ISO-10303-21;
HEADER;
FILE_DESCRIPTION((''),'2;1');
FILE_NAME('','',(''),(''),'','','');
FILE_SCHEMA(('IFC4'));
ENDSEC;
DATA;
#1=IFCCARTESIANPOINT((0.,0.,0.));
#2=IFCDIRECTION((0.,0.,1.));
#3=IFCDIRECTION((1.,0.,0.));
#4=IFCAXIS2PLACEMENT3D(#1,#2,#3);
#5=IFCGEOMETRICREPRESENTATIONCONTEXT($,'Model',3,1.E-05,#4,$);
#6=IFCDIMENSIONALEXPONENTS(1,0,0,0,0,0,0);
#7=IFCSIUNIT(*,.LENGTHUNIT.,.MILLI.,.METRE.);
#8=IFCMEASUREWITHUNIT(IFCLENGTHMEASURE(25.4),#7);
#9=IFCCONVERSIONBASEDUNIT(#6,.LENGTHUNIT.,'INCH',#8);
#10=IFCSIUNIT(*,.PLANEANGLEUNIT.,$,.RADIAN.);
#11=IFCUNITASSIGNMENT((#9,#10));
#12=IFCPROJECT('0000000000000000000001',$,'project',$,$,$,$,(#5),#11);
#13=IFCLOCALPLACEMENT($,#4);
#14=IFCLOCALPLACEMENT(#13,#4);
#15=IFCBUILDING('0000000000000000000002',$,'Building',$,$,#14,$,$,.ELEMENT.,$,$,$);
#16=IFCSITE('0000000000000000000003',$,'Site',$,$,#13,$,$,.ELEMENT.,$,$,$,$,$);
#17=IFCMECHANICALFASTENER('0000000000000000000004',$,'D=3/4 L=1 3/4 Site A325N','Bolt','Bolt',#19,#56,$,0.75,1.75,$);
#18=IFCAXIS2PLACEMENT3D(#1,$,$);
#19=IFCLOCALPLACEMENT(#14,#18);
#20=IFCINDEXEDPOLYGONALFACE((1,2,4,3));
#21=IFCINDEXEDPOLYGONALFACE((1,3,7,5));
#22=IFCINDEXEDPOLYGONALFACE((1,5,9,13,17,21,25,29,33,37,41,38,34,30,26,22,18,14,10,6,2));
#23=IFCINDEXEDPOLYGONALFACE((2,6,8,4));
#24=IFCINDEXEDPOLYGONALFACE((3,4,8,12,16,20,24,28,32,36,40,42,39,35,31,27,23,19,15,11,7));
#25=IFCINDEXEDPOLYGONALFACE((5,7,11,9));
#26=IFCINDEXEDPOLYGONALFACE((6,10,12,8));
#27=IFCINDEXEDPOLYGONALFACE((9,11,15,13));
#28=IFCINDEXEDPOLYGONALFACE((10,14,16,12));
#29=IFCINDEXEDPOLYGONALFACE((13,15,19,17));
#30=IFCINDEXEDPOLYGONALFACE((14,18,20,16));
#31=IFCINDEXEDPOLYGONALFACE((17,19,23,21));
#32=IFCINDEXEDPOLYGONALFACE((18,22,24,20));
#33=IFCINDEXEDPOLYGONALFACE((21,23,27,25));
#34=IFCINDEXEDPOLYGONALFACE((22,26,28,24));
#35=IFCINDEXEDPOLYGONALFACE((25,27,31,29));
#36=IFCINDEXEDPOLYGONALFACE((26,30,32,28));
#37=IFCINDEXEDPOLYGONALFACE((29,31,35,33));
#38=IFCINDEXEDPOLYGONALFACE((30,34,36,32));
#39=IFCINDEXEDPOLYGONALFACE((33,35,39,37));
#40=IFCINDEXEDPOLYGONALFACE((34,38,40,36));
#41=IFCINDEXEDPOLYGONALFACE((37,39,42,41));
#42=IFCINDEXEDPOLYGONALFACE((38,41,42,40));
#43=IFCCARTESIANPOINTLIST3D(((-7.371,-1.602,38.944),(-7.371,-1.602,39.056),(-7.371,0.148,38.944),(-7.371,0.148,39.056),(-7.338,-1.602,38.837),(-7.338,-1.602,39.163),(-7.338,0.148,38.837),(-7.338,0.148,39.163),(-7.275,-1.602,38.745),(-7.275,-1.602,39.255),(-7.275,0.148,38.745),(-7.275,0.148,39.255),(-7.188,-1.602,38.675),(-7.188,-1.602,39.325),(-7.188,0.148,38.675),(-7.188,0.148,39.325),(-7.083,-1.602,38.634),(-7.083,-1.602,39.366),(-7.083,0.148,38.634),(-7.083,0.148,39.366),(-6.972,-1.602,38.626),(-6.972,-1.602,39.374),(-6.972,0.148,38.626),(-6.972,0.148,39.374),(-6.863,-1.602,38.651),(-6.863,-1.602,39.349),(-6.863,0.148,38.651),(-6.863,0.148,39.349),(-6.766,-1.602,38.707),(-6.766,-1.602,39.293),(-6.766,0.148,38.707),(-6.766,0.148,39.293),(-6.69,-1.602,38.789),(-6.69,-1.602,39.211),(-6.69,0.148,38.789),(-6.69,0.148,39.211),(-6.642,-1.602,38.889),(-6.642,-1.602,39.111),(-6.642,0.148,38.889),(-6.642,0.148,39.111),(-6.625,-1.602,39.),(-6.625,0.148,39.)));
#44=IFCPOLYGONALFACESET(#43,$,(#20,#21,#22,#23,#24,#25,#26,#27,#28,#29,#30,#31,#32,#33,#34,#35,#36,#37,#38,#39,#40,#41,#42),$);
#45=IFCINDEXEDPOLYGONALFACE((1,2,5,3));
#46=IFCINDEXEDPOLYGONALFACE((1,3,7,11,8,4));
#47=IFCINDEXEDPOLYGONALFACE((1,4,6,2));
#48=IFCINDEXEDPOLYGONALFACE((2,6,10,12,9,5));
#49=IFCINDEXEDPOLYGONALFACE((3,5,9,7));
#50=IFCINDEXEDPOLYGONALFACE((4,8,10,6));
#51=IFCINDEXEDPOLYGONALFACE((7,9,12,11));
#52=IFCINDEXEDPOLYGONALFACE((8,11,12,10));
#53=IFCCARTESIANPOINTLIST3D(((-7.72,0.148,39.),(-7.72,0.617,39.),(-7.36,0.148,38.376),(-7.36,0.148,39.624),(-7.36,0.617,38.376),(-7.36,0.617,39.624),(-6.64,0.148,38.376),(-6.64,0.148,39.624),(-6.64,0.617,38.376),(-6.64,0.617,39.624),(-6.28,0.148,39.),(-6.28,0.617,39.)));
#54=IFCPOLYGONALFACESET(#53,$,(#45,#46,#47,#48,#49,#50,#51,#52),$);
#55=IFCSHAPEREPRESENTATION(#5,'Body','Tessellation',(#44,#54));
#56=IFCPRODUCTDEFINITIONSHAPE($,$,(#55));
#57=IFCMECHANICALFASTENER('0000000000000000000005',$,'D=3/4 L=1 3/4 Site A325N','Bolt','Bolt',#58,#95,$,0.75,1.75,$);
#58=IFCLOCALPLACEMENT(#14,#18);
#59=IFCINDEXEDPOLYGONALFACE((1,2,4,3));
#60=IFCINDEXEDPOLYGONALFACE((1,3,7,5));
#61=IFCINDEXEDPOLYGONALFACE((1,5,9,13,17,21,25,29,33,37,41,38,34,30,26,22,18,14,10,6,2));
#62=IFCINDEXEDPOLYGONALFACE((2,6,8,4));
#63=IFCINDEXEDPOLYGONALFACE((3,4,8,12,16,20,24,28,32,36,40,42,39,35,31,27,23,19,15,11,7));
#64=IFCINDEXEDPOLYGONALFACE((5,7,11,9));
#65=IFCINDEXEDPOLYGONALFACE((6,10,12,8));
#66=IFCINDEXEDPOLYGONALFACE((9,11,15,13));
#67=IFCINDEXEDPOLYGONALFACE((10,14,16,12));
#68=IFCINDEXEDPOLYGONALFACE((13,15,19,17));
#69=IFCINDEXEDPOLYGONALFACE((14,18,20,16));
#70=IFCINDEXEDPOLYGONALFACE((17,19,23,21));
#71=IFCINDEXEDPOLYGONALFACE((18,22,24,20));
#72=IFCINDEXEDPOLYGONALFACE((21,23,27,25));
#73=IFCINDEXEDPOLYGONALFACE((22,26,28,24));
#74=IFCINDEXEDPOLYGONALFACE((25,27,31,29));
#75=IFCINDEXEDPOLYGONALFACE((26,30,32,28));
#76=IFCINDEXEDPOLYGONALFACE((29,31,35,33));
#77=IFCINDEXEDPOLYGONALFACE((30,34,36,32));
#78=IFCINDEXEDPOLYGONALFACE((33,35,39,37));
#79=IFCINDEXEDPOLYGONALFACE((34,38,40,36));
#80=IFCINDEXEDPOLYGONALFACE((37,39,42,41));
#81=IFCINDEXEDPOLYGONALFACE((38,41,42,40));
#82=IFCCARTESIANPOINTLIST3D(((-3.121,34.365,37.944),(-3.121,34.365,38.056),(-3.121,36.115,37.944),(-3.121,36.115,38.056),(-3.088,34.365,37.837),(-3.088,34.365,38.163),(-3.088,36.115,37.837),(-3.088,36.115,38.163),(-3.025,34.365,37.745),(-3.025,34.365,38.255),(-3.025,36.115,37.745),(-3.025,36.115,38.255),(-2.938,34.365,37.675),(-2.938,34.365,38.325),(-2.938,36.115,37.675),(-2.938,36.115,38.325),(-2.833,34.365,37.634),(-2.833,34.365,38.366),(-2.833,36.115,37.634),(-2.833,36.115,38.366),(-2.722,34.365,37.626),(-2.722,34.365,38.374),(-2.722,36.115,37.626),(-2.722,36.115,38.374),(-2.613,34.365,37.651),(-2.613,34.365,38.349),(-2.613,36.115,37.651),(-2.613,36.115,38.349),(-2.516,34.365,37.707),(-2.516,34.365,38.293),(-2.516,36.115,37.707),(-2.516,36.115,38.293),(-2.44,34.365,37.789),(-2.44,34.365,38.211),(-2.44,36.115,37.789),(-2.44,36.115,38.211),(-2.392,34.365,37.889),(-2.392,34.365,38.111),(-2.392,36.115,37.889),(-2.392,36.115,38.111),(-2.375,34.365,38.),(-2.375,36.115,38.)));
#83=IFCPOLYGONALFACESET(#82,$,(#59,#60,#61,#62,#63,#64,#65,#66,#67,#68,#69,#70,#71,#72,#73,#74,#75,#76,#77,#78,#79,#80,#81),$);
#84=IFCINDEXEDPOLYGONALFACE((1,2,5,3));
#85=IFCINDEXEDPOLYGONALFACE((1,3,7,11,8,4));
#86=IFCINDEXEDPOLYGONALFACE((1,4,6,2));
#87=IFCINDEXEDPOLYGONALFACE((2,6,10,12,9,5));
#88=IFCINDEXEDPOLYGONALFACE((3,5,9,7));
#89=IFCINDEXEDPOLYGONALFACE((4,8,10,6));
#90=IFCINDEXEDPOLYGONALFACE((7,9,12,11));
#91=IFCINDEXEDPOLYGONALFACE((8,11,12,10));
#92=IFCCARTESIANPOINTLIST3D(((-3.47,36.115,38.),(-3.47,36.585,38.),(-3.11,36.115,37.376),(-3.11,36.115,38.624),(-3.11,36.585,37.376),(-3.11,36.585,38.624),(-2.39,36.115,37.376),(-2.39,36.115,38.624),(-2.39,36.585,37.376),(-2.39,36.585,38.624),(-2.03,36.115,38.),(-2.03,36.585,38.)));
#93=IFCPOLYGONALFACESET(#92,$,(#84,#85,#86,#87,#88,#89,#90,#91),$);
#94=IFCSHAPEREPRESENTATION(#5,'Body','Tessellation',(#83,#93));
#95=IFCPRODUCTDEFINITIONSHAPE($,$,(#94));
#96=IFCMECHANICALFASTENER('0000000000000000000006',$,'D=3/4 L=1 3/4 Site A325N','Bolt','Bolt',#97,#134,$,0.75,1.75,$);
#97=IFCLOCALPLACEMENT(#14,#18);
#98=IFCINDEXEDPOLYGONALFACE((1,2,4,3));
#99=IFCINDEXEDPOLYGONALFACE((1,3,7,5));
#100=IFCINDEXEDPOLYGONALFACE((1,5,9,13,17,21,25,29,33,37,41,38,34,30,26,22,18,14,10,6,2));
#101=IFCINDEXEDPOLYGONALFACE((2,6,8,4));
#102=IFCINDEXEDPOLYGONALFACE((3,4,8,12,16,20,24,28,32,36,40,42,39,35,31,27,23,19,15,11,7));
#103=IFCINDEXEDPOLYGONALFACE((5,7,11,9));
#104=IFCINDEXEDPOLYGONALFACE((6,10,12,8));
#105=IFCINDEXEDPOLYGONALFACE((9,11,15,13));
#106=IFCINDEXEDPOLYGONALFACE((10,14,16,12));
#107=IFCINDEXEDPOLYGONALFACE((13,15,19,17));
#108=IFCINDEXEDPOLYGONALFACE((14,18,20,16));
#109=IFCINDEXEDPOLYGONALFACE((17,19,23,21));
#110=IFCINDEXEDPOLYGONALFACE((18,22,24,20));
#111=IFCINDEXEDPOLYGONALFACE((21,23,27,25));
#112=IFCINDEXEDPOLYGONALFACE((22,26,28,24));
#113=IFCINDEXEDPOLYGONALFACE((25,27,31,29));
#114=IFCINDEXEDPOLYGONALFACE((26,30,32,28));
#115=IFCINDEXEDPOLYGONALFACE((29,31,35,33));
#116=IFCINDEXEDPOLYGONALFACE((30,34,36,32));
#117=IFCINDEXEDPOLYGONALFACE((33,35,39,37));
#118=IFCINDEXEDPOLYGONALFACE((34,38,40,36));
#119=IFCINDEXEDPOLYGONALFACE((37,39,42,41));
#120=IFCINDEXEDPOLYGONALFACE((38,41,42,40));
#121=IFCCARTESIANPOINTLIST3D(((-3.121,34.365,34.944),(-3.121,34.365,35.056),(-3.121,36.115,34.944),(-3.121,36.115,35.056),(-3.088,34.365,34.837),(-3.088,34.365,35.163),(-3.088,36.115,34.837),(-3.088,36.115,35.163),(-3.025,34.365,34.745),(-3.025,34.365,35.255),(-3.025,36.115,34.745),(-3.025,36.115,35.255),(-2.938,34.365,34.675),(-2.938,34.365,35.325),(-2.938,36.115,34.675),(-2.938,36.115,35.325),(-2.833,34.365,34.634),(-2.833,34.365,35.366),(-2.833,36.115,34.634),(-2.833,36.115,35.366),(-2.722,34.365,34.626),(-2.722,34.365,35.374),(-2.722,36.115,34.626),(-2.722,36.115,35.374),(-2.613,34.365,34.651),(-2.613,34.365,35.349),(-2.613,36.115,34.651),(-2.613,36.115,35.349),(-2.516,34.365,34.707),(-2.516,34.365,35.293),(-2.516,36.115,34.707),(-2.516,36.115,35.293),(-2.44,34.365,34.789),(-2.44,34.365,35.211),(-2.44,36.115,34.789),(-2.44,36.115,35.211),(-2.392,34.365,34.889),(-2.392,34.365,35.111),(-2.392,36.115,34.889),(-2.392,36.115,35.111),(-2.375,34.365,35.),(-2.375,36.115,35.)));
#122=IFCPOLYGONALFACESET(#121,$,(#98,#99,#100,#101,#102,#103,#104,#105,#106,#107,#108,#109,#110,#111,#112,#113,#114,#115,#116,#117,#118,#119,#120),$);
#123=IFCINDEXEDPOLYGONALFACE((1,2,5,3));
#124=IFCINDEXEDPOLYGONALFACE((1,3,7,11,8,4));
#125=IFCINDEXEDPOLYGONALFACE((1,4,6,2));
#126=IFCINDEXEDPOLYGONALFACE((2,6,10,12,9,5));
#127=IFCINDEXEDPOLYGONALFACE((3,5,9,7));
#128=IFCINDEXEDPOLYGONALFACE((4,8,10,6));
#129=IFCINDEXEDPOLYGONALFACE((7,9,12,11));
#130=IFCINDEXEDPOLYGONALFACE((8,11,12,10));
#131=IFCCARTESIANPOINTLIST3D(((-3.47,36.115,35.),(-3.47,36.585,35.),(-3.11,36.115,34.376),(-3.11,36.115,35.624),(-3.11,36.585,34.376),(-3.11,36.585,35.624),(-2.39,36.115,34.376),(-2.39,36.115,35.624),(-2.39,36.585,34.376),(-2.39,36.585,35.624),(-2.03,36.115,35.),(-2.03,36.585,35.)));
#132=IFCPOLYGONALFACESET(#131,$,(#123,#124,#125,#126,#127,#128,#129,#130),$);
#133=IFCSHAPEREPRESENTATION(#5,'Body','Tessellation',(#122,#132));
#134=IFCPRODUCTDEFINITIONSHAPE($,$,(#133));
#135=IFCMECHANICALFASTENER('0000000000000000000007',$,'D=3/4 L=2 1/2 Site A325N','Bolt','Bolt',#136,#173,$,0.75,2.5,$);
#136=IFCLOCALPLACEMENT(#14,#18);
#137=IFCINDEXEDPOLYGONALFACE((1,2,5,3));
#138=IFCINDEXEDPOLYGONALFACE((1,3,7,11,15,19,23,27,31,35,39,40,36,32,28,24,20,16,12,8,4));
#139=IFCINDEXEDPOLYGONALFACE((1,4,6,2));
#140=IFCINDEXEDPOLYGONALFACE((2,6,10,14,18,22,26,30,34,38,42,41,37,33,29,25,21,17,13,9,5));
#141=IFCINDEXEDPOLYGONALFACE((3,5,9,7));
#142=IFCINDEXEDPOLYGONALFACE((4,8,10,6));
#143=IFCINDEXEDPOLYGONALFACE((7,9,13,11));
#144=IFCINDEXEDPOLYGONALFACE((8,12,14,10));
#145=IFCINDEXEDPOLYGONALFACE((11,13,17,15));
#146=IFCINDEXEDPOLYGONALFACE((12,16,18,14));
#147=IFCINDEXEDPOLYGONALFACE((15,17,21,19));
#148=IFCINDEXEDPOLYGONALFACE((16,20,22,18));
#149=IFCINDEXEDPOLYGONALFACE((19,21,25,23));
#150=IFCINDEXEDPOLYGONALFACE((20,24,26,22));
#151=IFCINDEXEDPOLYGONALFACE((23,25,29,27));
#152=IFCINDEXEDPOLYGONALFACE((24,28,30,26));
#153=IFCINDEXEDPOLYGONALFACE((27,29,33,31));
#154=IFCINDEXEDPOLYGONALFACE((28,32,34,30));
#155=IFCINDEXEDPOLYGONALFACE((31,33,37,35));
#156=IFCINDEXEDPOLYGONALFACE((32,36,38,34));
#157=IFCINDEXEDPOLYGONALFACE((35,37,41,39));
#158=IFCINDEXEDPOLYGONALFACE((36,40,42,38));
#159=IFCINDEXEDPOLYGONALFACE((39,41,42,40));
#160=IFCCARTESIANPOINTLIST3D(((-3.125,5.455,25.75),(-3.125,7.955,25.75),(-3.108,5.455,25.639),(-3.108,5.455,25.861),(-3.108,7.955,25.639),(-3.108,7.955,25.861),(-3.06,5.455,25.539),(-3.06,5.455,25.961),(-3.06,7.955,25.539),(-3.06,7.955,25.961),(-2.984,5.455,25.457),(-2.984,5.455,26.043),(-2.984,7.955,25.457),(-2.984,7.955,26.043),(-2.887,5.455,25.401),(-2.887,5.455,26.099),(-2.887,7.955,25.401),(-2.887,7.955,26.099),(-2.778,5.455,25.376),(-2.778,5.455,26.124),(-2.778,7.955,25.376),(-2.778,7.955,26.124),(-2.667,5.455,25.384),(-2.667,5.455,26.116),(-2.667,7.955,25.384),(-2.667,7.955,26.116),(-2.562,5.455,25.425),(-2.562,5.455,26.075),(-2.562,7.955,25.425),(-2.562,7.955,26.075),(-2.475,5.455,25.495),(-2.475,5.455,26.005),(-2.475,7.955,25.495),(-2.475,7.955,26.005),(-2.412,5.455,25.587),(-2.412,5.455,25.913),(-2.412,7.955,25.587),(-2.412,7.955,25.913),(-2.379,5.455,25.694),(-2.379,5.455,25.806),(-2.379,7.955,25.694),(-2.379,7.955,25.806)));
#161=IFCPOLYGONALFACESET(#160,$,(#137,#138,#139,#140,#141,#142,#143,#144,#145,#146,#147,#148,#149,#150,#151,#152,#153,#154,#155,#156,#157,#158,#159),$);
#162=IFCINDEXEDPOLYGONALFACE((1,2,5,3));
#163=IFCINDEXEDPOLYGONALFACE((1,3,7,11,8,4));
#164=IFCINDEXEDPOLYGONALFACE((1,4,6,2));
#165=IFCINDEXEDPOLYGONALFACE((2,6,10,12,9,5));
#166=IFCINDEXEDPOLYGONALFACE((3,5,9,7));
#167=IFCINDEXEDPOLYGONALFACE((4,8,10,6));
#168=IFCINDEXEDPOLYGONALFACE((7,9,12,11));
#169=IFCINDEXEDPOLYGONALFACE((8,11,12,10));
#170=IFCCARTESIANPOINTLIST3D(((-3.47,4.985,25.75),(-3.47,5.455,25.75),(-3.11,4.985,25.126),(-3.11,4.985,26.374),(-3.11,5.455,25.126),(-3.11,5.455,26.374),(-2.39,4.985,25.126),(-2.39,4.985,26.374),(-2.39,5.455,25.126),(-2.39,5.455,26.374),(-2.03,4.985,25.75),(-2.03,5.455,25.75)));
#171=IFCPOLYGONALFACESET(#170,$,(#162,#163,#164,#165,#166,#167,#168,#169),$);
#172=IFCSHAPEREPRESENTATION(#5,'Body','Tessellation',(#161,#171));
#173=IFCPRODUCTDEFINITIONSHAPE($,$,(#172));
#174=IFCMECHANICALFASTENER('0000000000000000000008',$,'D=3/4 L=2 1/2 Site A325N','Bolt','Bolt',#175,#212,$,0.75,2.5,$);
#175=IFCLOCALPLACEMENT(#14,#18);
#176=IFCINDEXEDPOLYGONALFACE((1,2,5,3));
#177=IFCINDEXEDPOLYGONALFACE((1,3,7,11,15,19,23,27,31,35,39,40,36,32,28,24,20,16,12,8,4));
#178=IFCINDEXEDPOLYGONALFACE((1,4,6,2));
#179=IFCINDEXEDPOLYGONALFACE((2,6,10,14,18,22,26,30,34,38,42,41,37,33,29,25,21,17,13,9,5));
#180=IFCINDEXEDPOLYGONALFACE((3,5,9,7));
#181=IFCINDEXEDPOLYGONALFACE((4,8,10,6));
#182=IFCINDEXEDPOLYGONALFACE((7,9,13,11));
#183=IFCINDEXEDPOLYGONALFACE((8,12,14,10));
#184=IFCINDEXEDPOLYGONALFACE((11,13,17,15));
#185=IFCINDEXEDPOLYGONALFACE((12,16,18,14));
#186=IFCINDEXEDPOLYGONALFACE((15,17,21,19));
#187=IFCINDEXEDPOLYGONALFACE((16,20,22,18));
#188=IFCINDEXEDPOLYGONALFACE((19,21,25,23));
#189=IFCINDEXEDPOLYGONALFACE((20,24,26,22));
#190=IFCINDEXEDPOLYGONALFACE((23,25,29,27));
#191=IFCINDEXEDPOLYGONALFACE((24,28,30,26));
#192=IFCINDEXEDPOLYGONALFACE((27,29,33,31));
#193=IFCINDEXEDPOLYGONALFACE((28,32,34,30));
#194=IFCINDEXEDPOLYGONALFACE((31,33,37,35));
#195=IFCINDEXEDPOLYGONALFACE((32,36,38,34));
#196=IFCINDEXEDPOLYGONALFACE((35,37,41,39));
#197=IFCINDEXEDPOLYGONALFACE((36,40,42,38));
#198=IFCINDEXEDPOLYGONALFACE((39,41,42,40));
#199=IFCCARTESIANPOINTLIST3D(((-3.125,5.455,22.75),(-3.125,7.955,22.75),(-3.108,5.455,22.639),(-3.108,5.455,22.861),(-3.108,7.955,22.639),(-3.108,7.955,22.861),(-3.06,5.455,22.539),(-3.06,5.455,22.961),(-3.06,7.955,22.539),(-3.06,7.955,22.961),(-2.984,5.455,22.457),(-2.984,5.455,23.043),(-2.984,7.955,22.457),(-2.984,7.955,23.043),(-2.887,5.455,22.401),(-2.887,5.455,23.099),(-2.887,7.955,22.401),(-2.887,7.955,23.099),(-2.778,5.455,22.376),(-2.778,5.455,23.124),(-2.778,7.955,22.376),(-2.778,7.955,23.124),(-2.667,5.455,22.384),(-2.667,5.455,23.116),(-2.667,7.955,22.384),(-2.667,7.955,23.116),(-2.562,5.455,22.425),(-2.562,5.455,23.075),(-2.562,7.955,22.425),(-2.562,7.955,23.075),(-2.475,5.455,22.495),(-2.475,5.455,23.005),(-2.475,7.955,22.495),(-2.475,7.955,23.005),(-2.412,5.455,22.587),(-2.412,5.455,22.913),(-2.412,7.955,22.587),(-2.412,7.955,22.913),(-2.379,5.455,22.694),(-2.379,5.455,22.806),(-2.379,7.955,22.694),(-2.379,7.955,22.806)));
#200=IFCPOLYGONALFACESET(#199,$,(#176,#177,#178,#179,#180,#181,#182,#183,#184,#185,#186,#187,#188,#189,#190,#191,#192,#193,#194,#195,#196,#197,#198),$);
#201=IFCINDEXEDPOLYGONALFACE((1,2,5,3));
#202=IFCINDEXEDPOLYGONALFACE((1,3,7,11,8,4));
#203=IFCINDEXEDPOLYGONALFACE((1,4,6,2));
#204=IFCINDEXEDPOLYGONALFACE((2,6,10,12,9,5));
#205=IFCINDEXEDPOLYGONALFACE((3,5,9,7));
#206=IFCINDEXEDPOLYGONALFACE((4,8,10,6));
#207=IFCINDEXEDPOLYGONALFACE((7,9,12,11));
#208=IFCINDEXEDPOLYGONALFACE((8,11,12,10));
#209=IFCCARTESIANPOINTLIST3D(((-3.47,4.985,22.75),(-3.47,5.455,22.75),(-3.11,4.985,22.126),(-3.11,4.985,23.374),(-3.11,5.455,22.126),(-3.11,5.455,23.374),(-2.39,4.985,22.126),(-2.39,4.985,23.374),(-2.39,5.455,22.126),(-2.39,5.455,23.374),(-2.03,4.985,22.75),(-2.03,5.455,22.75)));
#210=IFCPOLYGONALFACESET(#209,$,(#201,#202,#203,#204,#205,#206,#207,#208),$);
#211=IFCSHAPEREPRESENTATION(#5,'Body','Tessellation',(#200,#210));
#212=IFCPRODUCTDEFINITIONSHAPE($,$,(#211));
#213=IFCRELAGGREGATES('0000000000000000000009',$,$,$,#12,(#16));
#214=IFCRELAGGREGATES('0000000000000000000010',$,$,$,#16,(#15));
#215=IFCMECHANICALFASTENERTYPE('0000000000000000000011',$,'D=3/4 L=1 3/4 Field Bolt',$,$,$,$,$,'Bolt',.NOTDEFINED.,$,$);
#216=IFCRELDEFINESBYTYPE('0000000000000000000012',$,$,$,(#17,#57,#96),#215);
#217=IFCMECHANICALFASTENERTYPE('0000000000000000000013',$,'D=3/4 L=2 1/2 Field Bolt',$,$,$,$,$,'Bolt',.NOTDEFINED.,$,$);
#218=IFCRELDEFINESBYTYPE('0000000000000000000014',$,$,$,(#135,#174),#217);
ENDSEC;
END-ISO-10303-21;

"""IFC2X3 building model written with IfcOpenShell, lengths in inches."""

from ifc_helpers import new_model, entity, si_unit, converted_unit, frame, origin_with_axes, origin_2d_with_axis, place, context, project, spatial, polyline, circle, outline, extrude, source, transform, mapped, type_object, type_shapes, element, save


model = new_model("IFC2X3")

# Units and contexts
model_context = context("Model", 3, precision=1e-05, world=origin_with_axes())
ifc_project = project(units=[converted_unit("LENGTHUNIT", "INCH", entity("IfcLengthMeasure", 25.4), si_unit("LENGTHUNIT", "METRE", prefix="MILLI"), dimensions=[1, 0, 0, 0, 0, 0, 0]), si_unit("PLANEANGLEUNIT", "RADIAN")], contexts=[model_context])

# Site, building
site_placement = place(None, origin_with_axes())
site = spatial("IfcSite", under=ifc_project, at=site_placement, Name="Site", CompositionType="ELEMENT")
building_placement = place(site_placement, origin_with_axes())
building = spatial("IfcBuilding", under=site, at=building_placement, Name="Building", CompositionType="ELEMENT")

# Shared definitions
assembly_1_placement = place(building_placement, frame((0.0, 0.0, 21.0), z_axis=(0.0, -1.0, 0.0), x_axis=(0.0, 0.0, 1.0)))

# Mechanical fasteners
mechanical_fastener_type_1 = type_object("IfcMechanicalFastenerType", Name="D=3/4 L=1 3/4 Field Bolt", ElementType="Bolt")
shared_shape_1 = source(origin_with_axes(), model_context, "Body", "SweptSolid", [
    extrude(circle(Radius=0.375, at=origin_2d_with_axis()), frame((0.0, 0.0, 0.0), z_axis=(1.0, 0.0, 0.0), x_axis=(0.0, 1.0, 0.0)), (0.0, 0.0, 1.0), 1.75),
    extrude(outline(polyline([(-0.72, 0.0), (-0.36, 0.624), (0.36, 0.624), (0.72, 0.0), (0.36, -0.624), (-0.36, -0.624), (-0.72, 0.0)])), frame((0.0, 0.0, 0.0), z_axis=(1.0, 0.0, 0.0), x_axis=(0.0, 1.0, 0.0)), (0.0, 0.0, -1.0), 0.47),
])
type_shapes(mechanical_fastener_type_1, [shared_shape_1])
placement_1 = place(building_placement, frame((0.0, 0.0, 46.0), z_axis=(0.0, 0.0, 1.0), x_axis=(-1.0, 0.0, 0.0)))
placement_2 = place(placement_1, frame((7.0, -0.148, -4.0), z_axis=(0.0, 0.0, 1.0), x_axis=(0.0, 1.0, 0.0)))
for number, where, z_axis, x_axis, name in (
    (1, (0.0, 0.0, -3.0), (0.0, 0.0, 1.0), (1.0, 0.0, 0.0), "D=3/4 L=1 3/4 Site A325N"),
):
    element("IfcMechanicalFastener", number, at=place(placement_2, frame(where, z_axis=z_axis, x_axis=x_axis)), type_object=mechanical_fastener_type_1, Name=name, Description="Bolt", ObjectType="Bolt", NominalDiameter=0.75, NominalLength=1.75, context=model_context, shape_type="MappedRepresentation", body=[
        mapped(shared_shape_1, transform((0.0, 0.0, 0.0), scale=1.0)),
    ])
placement_3 = place(building_placement, frame((0.0, 36.0, 44.0), z_axis=(0.0, 0.0, 1.0), x_axis=(-1.0, 0.0, 0.0)))
placement_4 = place(placement_3, frame((2.75, -0.115, -9.0), z_axis=(0.0, 0.0, 1.0), x_axis=(0.0, 1.0, 0.0)))
for number, where, z_axis, x_axis, name in (
    (2, (0.0, 0.0, 3.0), (0.0, 0.0, 1.0), (1.0, 0.0, 0.0), "D=3/4 L=1 3/4 Site A325N"),
    (3, (0.0, 0.0, 0.0), (0.0, 0.0, 1.0), (1.0, 0.0, 0.0), "D=3/4 L=1 3/4 Site A325N"),
):
    element("IfcMechanicalFastener", number, at=place(placement_4, frame(where, z_axis=z_axis, x_axis=x_axis)), type_object=mechanical_fastener_type_1, Name=name, Description="Bolt", ObjectType="Bolt", NominalDiameter=0.75, NominalLength=1.75, context=model_context, shape_type="MappedRepresentation", body=[
        mapped(shared_shape_1, transform((0.0, 0.0, 0.0), scale=1.0)),
    ])
mechanical_fastener_type_2 = type_object("IfcMechanicalFastenerType", Name="D=3/4 L=2 1/2 Field Bolt", ElementType="Bolt")
shared_shape_2 = source(origin_with_axes(), model_context, "Body", "SweptSolid", [
    extrude(circle(Radius=0.375, at=origin_2d_with_axis()), frame((0.0, 0.0, 0.0), z_axis=(1.0, 0.0, 0.0), x_axis=(0.0, 1.0, 0.0)), (0.0, 0.0, 1.0), 2.5),
    extrude(outline(polyline([(-0.72, 0.0), (-0.36, 0.624), (0.36, 0.624), (0.72, 0.0), (0.36, -0.624), (-0.36, -0.624), (-0.72, 0.0)])), frame((0.0, 0.0, 0.0), z_axis=(1.0, 0.0, 0.0), x_axis=(0.0, 1.0, 0.0)), (0.0, 0.0, -1.0), 0.47),
])
type_shapes(mechanical_fastener_type_2, [shared_shape_2])
placement_5 = place(assembly_1_placement, frame((4.75, -2.75, -5.455), z_axis=(1.0, 0.0, 0.0), x_axis=(0.0, 0.0, -1.0)))
for number, where, z_axis, x_axis, name in (
    (4, (0.0, 5.5, 0.0), (0.0, 0.0, 1.0), (1.0, 0.0, 0.0), "D=3/4 L=2 1/2 Site A325N"),
    (5, (0.0, 5.5, -3.0), (0.0, 0.0, 1.0), (1.0, 0.0, 0.0), "D=3/4 L=2 1/2 Site A325N"),
):
    element("IfcMechanicalFastener", number, at=place(placement_5, frame(where, z_axis=z_axis, x_axis=x_axis)), type_object=mechanical_fastener_type_2, Name=name, Description="Bolt", ObjectType="Bolt", NominalDiameter=0.75, NominalLength=2.5, context=model_context, shape_type="MappedRepresentation", body=[
        mapped(shared_shape_2, transform((0.0, 0.0, 0.0), scale=1.0)),
    ])

save(model, "model.ifc")
